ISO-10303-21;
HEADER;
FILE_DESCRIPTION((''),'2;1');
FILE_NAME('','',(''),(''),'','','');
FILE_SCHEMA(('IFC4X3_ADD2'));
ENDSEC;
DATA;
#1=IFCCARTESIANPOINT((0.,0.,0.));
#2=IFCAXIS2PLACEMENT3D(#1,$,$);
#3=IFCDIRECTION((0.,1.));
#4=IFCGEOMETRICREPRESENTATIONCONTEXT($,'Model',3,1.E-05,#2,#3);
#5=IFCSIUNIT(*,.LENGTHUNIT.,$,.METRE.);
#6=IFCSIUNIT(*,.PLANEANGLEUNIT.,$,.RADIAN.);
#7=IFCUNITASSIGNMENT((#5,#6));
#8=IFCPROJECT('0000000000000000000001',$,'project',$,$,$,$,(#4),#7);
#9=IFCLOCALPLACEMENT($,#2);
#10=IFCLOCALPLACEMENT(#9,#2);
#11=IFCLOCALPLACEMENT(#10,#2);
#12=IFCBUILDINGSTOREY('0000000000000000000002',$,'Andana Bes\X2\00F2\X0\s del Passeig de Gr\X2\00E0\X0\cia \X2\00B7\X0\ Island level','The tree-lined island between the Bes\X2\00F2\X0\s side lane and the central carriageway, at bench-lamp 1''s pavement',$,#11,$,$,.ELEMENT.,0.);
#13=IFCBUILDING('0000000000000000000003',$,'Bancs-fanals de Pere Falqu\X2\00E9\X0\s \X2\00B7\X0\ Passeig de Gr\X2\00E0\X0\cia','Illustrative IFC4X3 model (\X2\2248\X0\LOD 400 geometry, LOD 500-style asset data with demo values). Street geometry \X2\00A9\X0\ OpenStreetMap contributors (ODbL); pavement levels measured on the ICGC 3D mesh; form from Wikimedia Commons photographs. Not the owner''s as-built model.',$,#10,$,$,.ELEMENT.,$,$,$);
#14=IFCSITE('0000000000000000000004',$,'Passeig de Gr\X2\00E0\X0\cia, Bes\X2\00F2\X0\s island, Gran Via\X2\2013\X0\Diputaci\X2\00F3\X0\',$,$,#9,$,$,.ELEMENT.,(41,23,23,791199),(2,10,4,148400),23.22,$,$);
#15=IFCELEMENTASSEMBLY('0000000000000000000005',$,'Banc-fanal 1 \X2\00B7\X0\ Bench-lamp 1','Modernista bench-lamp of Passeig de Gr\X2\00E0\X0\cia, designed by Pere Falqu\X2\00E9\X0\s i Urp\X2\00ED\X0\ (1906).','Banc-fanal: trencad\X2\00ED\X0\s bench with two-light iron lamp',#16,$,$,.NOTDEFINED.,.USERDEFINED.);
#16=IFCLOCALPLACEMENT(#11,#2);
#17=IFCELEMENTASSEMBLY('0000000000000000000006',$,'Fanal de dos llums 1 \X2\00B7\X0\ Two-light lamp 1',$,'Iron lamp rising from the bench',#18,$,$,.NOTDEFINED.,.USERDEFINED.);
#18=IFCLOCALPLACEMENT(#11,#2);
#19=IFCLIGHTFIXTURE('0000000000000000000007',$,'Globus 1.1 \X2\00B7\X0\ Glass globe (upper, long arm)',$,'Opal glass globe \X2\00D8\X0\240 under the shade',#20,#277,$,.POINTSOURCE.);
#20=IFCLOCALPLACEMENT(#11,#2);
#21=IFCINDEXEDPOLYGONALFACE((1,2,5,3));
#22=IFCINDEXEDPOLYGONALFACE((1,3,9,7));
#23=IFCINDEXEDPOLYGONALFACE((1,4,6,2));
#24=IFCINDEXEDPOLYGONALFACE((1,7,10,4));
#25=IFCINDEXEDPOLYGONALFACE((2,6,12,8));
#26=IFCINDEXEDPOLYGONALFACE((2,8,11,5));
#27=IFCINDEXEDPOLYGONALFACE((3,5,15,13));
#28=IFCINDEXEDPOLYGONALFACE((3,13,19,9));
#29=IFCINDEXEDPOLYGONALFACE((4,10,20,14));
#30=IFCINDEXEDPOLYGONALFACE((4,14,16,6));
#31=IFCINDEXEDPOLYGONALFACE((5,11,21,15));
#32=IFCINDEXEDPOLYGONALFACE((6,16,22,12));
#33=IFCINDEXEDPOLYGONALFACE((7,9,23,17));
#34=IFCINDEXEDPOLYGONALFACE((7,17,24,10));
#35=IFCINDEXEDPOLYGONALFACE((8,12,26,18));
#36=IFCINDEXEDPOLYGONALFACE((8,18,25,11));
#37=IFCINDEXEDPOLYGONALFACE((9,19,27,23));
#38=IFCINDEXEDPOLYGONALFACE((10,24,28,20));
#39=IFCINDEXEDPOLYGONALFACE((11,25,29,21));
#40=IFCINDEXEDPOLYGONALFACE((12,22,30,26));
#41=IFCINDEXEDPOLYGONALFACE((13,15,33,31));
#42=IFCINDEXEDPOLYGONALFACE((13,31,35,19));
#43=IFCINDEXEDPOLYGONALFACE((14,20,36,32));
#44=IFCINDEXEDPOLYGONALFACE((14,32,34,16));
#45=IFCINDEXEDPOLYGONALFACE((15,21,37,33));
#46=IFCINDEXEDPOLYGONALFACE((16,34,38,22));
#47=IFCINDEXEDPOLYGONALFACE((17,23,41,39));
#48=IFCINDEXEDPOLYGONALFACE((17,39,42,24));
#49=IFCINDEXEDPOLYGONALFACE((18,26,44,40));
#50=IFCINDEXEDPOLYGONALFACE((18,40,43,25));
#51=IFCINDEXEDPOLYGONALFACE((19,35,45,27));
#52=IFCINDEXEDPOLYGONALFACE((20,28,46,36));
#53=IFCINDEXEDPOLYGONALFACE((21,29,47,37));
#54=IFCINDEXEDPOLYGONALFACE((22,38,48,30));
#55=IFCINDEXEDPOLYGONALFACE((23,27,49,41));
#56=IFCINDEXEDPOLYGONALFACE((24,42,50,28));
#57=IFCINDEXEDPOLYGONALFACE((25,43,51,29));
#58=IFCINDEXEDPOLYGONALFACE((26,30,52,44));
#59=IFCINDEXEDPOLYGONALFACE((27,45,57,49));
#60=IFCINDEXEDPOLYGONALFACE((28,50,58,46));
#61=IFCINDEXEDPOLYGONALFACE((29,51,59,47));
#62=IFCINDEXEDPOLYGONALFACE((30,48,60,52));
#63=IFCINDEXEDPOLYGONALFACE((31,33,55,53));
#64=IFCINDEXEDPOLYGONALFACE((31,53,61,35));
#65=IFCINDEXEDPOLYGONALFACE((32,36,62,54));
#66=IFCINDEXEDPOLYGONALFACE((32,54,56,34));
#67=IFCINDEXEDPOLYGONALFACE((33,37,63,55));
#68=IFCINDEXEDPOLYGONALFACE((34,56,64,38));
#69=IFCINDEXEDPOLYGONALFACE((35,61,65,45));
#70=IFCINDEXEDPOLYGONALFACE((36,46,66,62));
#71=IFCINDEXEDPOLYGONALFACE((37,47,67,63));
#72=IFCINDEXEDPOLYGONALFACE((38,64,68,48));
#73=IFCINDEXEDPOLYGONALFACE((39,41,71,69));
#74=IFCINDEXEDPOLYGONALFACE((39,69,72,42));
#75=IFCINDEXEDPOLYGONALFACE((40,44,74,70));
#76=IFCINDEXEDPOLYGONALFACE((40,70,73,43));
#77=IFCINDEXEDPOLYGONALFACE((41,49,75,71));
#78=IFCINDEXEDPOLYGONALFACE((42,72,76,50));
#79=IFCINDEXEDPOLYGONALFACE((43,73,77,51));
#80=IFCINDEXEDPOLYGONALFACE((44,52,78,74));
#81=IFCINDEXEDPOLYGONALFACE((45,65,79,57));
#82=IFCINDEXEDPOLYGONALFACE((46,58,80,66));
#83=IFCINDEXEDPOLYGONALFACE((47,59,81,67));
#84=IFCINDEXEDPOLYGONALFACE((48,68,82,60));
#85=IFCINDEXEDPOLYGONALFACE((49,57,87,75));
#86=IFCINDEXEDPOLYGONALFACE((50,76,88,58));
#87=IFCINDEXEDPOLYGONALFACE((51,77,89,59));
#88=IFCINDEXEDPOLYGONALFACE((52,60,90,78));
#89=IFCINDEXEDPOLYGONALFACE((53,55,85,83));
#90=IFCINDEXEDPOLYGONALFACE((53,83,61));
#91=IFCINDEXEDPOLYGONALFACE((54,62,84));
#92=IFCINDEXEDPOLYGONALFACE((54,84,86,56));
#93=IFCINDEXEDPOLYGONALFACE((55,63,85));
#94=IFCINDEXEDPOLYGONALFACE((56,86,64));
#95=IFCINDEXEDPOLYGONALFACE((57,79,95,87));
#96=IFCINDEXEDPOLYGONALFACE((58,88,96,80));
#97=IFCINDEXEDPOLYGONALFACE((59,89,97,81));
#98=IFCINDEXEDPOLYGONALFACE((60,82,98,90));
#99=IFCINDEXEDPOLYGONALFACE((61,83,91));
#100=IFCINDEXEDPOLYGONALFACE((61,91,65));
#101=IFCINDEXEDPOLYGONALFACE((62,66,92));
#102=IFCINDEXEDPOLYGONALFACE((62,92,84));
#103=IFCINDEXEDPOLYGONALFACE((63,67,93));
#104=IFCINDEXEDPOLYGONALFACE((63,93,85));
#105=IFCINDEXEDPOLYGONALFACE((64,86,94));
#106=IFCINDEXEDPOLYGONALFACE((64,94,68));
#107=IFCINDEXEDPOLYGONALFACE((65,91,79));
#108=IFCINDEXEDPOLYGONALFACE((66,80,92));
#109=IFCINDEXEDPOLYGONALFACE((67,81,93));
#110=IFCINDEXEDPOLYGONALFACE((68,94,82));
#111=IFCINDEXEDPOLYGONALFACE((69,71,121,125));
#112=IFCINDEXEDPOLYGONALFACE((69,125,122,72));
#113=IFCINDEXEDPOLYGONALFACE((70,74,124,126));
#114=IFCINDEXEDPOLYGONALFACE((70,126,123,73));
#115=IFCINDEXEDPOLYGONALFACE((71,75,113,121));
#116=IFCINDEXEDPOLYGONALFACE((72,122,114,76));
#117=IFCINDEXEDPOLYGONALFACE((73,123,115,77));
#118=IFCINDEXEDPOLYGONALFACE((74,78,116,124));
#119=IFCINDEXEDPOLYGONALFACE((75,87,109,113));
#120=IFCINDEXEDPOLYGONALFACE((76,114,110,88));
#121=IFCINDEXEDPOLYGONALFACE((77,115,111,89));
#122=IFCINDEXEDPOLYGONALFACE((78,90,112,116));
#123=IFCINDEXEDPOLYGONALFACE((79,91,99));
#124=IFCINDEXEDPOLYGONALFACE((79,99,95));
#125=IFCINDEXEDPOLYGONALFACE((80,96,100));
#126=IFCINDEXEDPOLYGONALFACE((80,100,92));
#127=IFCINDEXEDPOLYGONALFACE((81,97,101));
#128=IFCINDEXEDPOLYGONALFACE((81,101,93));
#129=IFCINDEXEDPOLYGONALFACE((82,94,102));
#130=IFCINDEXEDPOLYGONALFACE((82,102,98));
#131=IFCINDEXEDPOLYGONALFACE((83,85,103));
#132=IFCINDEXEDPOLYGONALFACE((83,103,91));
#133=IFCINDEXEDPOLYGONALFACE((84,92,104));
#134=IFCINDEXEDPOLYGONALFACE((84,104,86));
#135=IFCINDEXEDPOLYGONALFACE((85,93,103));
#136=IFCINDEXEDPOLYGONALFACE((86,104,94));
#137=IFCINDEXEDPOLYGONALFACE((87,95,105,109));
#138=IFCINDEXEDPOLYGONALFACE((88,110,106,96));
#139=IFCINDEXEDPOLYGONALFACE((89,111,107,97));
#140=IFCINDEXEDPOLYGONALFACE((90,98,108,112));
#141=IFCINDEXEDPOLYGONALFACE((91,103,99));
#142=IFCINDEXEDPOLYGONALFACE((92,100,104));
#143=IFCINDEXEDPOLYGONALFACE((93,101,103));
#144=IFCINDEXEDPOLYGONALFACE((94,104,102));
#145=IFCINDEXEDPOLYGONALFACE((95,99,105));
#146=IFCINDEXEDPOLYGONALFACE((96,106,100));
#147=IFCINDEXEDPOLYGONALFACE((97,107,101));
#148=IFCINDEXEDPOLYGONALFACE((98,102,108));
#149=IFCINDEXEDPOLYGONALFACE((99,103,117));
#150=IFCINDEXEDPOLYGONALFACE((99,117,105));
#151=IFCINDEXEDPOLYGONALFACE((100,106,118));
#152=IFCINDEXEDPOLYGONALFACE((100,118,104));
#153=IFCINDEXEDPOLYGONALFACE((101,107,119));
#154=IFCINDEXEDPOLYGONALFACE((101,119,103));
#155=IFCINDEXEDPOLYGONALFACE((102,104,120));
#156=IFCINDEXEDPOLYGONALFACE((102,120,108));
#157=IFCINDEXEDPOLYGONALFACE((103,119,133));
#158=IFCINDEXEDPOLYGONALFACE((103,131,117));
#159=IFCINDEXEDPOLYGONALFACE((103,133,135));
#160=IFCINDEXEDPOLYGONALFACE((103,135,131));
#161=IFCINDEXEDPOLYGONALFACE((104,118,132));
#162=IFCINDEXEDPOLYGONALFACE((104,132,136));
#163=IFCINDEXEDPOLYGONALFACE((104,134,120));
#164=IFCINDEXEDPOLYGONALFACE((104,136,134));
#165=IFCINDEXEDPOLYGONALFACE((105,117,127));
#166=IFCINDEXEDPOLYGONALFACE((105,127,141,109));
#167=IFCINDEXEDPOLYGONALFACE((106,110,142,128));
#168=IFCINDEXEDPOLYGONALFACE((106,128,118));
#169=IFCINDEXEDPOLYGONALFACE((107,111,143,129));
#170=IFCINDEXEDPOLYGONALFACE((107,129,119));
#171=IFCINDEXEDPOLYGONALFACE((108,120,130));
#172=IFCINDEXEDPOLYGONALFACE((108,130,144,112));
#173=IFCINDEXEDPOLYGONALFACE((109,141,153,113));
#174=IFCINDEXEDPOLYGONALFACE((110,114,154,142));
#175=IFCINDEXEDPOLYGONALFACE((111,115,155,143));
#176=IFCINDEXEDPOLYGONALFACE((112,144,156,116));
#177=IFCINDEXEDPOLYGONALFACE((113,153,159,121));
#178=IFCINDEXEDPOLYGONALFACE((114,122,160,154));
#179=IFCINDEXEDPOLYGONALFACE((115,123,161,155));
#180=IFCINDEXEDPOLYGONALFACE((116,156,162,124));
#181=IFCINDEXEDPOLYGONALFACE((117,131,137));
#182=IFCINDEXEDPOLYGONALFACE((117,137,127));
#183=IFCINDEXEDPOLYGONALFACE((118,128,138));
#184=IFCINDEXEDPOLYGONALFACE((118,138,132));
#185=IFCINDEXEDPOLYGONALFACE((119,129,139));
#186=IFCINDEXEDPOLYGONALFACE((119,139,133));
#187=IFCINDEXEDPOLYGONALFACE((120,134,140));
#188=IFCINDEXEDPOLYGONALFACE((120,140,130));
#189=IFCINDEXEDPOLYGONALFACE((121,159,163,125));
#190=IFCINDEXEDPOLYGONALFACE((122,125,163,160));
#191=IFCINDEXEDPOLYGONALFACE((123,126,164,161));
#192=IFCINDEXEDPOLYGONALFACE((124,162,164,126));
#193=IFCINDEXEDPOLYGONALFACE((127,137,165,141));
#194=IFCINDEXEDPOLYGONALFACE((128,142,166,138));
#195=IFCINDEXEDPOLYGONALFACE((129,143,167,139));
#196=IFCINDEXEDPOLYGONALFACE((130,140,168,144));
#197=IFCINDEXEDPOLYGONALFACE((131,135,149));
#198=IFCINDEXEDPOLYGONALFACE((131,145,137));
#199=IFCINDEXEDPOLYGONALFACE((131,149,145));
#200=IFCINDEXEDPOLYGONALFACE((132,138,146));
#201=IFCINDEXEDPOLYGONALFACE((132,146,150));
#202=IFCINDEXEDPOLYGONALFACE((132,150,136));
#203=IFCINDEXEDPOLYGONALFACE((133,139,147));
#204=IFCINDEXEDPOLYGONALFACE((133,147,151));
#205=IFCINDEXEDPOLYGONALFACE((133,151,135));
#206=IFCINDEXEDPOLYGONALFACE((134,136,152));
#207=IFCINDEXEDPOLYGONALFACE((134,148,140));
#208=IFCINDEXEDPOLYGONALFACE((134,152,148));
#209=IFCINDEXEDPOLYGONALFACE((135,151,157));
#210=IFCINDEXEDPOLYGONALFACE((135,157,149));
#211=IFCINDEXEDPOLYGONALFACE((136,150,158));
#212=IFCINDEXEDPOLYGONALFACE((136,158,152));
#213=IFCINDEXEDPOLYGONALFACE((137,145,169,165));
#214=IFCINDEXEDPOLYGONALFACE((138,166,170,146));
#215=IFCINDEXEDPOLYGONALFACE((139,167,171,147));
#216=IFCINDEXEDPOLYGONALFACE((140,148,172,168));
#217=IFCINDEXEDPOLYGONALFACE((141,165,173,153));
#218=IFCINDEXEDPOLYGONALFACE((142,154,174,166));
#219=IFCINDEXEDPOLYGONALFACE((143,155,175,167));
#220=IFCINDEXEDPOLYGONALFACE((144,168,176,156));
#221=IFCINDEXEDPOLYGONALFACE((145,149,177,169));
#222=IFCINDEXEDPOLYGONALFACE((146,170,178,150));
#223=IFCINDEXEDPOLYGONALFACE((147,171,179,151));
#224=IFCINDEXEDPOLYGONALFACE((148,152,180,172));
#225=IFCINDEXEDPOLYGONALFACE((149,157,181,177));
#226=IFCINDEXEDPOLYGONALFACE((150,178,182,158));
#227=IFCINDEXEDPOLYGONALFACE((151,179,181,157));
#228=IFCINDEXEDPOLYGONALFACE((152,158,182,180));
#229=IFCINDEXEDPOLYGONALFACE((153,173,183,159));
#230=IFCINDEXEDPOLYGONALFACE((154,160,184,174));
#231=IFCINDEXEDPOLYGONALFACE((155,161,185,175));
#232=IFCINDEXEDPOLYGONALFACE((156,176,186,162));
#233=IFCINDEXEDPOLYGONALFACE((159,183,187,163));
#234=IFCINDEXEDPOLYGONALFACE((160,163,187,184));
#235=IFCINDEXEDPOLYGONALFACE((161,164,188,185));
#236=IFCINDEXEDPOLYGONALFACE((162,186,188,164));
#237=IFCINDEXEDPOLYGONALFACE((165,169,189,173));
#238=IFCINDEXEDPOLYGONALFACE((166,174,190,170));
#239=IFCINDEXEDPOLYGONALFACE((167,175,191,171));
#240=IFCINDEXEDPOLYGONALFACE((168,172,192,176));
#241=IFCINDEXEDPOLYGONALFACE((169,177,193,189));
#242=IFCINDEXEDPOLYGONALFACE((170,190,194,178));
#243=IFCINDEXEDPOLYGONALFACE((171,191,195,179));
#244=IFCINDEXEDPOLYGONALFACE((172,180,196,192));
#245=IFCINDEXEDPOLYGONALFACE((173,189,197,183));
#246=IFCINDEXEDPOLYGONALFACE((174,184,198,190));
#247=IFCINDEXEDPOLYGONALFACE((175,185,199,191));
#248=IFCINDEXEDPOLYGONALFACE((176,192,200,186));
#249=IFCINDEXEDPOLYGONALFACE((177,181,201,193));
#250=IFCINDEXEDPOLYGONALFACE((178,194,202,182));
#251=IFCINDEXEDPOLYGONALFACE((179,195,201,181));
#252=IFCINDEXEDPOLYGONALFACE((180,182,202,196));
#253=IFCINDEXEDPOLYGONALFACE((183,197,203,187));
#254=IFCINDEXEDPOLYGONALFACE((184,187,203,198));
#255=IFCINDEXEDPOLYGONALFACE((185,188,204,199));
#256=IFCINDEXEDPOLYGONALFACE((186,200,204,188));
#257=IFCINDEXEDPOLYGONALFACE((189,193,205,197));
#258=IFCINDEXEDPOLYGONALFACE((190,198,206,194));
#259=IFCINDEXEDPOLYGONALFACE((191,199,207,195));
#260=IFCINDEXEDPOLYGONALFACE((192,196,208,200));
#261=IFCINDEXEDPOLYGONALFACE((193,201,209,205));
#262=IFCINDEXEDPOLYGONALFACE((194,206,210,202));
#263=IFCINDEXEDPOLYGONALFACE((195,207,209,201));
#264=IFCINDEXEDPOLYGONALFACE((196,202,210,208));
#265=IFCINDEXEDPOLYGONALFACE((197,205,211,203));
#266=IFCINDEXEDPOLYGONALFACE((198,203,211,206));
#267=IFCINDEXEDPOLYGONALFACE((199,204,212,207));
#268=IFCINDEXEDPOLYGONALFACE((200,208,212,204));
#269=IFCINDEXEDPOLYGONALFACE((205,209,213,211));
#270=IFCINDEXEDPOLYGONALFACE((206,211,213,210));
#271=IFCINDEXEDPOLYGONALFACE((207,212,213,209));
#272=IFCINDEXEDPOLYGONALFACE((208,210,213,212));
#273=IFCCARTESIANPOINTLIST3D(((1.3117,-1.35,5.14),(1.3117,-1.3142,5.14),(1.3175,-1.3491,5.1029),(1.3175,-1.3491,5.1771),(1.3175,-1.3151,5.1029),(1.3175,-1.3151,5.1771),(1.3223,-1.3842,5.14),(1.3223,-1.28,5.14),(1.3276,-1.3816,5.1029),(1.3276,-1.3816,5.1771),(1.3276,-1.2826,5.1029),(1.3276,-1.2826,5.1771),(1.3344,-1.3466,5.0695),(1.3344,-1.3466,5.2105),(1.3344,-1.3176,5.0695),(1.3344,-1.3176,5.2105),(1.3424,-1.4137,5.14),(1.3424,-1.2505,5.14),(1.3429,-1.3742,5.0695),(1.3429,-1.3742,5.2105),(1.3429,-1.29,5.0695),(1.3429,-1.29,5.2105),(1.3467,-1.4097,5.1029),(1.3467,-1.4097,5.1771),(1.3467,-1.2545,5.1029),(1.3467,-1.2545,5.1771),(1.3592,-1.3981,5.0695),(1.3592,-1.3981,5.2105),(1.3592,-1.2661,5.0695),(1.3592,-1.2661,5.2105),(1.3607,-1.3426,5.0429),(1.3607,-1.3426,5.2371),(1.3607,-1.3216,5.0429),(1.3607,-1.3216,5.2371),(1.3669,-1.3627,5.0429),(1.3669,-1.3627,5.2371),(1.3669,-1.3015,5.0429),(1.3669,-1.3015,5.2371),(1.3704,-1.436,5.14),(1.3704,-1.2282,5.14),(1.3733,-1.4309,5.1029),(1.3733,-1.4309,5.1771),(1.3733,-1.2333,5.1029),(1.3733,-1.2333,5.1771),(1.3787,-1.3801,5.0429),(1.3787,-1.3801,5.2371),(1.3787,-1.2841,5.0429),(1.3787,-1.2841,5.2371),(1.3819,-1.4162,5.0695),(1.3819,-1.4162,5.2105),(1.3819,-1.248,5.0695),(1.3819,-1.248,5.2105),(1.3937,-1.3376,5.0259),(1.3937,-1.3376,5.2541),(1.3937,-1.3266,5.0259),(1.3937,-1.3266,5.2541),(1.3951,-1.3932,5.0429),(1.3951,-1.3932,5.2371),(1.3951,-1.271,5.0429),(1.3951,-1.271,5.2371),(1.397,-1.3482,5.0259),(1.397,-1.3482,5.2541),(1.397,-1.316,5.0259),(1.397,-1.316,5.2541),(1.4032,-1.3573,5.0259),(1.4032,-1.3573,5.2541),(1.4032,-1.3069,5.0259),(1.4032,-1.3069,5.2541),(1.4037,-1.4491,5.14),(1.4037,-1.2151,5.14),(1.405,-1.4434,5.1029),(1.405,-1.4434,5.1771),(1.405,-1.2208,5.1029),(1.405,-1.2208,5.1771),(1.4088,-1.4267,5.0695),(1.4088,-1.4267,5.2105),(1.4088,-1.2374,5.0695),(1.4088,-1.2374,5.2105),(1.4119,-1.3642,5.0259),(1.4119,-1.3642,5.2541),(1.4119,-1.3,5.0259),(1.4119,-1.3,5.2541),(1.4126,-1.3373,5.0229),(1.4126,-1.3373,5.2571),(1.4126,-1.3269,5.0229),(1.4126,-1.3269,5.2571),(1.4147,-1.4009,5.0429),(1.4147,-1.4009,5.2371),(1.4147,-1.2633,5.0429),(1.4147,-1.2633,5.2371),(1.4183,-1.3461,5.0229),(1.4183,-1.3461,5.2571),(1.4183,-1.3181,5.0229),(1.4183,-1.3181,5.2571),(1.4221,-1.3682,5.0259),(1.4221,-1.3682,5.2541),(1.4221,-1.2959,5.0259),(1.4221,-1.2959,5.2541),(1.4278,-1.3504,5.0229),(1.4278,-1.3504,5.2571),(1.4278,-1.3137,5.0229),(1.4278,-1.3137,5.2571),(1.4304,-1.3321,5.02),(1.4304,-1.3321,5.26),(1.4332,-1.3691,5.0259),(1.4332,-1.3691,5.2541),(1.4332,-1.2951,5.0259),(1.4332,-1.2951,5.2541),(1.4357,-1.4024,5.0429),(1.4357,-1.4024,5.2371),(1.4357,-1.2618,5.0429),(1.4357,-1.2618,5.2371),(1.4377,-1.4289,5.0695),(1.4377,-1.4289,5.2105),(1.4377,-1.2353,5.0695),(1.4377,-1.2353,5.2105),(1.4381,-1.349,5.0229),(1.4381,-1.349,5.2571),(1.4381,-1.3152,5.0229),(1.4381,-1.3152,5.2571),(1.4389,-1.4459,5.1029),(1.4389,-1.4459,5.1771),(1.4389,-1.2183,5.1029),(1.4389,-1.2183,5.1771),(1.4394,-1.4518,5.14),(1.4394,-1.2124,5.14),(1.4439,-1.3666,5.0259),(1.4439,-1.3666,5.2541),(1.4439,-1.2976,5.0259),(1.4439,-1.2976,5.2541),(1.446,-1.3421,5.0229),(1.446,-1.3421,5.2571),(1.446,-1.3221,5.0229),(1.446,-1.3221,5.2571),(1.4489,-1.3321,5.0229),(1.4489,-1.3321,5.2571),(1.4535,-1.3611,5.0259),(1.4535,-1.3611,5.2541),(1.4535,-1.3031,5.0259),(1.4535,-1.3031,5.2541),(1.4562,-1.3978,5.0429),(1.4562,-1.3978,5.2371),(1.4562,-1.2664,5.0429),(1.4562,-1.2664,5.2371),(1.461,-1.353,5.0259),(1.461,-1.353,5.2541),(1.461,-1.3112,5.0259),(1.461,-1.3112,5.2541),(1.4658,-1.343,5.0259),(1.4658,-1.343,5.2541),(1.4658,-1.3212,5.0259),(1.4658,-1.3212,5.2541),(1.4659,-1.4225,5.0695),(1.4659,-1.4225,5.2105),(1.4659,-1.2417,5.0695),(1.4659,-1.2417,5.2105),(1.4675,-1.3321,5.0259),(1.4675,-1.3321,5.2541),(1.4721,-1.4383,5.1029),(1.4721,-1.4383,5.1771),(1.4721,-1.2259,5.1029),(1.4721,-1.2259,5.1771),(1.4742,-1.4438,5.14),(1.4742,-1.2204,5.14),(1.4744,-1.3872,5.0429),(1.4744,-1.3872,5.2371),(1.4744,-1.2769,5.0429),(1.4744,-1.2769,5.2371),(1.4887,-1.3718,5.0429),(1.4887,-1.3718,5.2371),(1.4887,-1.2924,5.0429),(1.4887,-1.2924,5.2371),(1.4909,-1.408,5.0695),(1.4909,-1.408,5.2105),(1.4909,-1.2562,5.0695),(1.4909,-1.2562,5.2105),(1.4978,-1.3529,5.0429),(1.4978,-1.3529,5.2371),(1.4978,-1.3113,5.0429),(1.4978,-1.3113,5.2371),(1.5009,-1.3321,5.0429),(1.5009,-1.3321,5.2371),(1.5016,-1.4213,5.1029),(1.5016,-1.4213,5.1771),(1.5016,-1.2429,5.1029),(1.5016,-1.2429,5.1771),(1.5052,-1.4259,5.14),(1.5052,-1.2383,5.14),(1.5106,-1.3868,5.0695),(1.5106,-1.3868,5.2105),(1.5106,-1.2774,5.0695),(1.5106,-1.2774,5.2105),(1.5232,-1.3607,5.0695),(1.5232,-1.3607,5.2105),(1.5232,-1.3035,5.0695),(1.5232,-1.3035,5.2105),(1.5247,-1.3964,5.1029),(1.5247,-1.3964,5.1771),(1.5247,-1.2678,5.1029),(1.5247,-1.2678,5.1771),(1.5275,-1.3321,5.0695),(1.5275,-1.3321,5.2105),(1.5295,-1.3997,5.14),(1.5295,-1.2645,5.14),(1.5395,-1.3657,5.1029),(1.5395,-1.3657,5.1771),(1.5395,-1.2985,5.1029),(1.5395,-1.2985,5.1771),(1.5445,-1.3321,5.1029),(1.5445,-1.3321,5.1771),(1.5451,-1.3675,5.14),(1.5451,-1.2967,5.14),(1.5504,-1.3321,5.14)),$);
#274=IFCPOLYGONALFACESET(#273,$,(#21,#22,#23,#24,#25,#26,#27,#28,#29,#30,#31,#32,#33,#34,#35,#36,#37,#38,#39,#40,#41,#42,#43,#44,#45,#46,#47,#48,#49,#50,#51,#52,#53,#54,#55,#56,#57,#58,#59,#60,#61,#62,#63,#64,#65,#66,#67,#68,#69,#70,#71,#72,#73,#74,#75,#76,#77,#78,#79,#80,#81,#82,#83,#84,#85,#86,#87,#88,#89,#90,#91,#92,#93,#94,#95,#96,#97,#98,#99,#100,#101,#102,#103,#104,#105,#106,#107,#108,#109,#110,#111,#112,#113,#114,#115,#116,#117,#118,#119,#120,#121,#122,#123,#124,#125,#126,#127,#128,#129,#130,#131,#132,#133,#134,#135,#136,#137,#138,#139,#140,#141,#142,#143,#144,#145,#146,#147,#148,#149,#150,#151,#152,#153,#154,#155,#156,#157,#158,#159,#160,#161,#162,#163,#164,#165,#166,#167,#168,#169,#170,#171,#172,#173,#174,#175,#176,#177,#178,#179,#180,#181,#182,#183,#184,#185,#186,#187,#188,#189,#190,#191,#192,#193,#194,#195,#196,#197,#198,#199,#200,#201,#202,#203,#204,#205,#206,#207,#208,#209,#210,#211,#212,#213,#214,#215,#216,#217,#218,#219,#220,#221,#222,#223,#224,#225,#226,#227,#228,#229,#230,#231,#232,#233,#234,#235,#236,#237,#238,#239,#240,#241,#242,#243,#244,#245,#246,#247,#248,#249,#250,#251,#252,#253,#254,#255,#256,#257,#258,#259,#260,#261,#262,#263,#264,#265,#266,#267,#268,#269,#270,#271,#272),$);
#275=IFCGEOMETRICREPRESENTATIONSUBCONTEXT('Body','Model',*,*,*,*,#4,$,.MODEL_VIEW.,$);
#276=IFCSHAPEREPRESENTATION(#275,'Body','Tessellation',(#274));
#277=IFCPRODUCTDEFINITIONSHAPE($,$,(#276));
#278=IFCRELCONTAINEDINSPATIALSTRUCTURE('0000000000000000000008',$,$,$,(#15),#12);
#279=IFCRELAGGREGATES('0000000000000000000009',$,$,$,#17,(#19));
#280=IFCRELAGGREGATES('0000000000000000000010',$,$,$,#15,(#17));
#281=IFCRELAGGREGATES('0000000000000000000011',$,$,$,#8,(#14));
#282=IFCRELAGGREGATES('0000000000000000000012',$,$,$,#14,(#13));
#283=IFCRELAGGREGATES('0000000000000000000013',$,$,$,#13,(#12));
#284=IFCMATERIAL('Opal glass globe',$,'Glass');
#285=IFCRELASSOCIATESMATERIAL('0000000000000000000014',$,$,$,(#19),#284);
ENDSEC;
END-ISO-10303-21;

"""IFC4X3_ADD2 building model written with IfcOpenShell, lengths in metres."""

from ifc_helpers import new_model, entity, si_unit, direction, origin, place, context, subcontext, project, spatial, material, element, aggregate, save


model = new_model("IFC4X3_ADD2")

# Units and contexts
model_context = context("Model", 3, precision=1e-05, world=origin(), true_north=direction((0.0, 1.0)))
body_context = subcontext(model_context, "Body", "Model", "MODEL_VIEW")
ifc_project = project(units=[si_unit("LENGTHUNIT", "METRE"), si_unit("PLANEANGLEUNIT", "RADIAN")], contexts=[model_context])

# Site, building, storey
site_placement = place(None, origin())
site = spatial("IfcSite", under=ifc_project, at=site_placement, Name="Passeig de Gràcia, Besòs island, Gran Via–Diputació", CompositionType="ELEMENT", RefLatitude=(41, 23, 23, 791199), RefLongitude=(2, 10, 4, 148400), RefElevation=23.22)
building_placement = place(site_placement, origin())
building = spatial("IfcBuilding", under=site, at=building_placement, Name="Bancs-fanals de Pere Falqués · Passeig de Gràcia", Description="Illustrative IFC4X3 model (≈LOD 400 geometry, LOD 500-style asset data with demo values). Street geometry © OpenStreetMap contributors (ODbL); pavement levels measured on the ICGC 3D mesh; form from Wikimedia Commons photographs. Not the owner's as-built model.", CompositionType="ELEMENT")
storey_placement = place(building_placement, origin())
storey = spatial("IfcBuildingStorey", under=building, at=storey_placement, Name="Andana Besòs del Passeig de Gràcia · Island level", Description="The tree-lined island between the Besòs side lane and the central carriageway, at bench-lamp 1's pavement", CompositionType="ELEMENT", Elevation=0.0)

# Element assembly
assembly_1_placement = place(building_placement, origin())
assembly_1 = element("IfcElementAssembly", 1, at=assembly_1_placement, inside=storey, Name="Banc-fanal 1 · Bench-lamp 1", Description="Modernista bench-lamp of Passeig de Gràcia, designed by Pere Falqués i Urpí (1906).", ObjectType="Banc-fanal: trencadís bench with two-light iron lamp", AssemblyPlace="NOTDEFINED", PredefinedType="USERDEFINED")

# Element assembly
assembly_2_placement = place(building_placement, origin())
assembly_2 = element("IfcElementAssembly", 2, at=assembly_2_placement, Name="Fanal de dos llums 1 · Two-light lamp 1", ObjectType="Iron lamp rising from the bench", AssemblyPlace="NOTDEFINED", PredefinedType="USERDEFINED")

# Light fixture
ifc_material_1 = material(Name="Opal glass globe", Category="Glass")
light_fixture_1_placement = place(building_placement, origin())
light_fixture_1 = element("IfcLightFixture", 3, at=light_fixture_1_placement, material=ifc_material_1, Name="Globus 1.1 · Glass globe (upper, long arm)", ObjectType="Opal glass globe Ø240 under the shade", PredefinedType="POINTSOURCE", context=body_context, shape_type="SweptSolid", body=[
    entity("IfcRevolvedAreaSolid", entity("IfcArbitraryClosedProfileDef", "AREA", None, entity("IfcPolyline", [entity("IfcCartesianPoint", [0.0, -0.12]), entity("IfcCartesianPoint", [0.0371, -0.1141]), entity("IfcCartesianPoint", [0.0705, -0.0971]), entity("IfcCartesianPoint", [0.0971, -0.0705]), entity("IfcCartesianPoint", [0.1141, -0.0371]), entity("IfcCartesianPoint", [0.12, 0.0]), entity("IfcCartesianPoint", [0.1141, 0.0371]), entity("IfcCartesianPoint", [0.0971, 0.0705]), entity("IfcCartesianPoint", [0.0705, 0.0971]), entity("IfcCartesianPoint", [0.0371, 0.1141]), entity("IfcCartesianPoint", [0.0, 0.12]), entity("IfcCartesianPoint", [0.0, -0.12])])), entity("IfcAxis2Placement3D", entity("IfcCartesianPoint", [1.4304, -1.3321, 5.14]), entity("IfcDirection", [0.0, -1.0, 0.0]), entity("IfcDirection", [1.0, 0.0, 0.0])), entity("IfcAxis1Placement", entity("IfcCartesianPoint", [0.0, 0.0, 0.0]), entity("IfcDirection", [0.0, 1.0, 0.0])), 6.283185),
])

aggregate(assembly_2, [light_fixture_1])

aggregate(assembly_1, [assembly_2])

save(model, "model.ifc")
